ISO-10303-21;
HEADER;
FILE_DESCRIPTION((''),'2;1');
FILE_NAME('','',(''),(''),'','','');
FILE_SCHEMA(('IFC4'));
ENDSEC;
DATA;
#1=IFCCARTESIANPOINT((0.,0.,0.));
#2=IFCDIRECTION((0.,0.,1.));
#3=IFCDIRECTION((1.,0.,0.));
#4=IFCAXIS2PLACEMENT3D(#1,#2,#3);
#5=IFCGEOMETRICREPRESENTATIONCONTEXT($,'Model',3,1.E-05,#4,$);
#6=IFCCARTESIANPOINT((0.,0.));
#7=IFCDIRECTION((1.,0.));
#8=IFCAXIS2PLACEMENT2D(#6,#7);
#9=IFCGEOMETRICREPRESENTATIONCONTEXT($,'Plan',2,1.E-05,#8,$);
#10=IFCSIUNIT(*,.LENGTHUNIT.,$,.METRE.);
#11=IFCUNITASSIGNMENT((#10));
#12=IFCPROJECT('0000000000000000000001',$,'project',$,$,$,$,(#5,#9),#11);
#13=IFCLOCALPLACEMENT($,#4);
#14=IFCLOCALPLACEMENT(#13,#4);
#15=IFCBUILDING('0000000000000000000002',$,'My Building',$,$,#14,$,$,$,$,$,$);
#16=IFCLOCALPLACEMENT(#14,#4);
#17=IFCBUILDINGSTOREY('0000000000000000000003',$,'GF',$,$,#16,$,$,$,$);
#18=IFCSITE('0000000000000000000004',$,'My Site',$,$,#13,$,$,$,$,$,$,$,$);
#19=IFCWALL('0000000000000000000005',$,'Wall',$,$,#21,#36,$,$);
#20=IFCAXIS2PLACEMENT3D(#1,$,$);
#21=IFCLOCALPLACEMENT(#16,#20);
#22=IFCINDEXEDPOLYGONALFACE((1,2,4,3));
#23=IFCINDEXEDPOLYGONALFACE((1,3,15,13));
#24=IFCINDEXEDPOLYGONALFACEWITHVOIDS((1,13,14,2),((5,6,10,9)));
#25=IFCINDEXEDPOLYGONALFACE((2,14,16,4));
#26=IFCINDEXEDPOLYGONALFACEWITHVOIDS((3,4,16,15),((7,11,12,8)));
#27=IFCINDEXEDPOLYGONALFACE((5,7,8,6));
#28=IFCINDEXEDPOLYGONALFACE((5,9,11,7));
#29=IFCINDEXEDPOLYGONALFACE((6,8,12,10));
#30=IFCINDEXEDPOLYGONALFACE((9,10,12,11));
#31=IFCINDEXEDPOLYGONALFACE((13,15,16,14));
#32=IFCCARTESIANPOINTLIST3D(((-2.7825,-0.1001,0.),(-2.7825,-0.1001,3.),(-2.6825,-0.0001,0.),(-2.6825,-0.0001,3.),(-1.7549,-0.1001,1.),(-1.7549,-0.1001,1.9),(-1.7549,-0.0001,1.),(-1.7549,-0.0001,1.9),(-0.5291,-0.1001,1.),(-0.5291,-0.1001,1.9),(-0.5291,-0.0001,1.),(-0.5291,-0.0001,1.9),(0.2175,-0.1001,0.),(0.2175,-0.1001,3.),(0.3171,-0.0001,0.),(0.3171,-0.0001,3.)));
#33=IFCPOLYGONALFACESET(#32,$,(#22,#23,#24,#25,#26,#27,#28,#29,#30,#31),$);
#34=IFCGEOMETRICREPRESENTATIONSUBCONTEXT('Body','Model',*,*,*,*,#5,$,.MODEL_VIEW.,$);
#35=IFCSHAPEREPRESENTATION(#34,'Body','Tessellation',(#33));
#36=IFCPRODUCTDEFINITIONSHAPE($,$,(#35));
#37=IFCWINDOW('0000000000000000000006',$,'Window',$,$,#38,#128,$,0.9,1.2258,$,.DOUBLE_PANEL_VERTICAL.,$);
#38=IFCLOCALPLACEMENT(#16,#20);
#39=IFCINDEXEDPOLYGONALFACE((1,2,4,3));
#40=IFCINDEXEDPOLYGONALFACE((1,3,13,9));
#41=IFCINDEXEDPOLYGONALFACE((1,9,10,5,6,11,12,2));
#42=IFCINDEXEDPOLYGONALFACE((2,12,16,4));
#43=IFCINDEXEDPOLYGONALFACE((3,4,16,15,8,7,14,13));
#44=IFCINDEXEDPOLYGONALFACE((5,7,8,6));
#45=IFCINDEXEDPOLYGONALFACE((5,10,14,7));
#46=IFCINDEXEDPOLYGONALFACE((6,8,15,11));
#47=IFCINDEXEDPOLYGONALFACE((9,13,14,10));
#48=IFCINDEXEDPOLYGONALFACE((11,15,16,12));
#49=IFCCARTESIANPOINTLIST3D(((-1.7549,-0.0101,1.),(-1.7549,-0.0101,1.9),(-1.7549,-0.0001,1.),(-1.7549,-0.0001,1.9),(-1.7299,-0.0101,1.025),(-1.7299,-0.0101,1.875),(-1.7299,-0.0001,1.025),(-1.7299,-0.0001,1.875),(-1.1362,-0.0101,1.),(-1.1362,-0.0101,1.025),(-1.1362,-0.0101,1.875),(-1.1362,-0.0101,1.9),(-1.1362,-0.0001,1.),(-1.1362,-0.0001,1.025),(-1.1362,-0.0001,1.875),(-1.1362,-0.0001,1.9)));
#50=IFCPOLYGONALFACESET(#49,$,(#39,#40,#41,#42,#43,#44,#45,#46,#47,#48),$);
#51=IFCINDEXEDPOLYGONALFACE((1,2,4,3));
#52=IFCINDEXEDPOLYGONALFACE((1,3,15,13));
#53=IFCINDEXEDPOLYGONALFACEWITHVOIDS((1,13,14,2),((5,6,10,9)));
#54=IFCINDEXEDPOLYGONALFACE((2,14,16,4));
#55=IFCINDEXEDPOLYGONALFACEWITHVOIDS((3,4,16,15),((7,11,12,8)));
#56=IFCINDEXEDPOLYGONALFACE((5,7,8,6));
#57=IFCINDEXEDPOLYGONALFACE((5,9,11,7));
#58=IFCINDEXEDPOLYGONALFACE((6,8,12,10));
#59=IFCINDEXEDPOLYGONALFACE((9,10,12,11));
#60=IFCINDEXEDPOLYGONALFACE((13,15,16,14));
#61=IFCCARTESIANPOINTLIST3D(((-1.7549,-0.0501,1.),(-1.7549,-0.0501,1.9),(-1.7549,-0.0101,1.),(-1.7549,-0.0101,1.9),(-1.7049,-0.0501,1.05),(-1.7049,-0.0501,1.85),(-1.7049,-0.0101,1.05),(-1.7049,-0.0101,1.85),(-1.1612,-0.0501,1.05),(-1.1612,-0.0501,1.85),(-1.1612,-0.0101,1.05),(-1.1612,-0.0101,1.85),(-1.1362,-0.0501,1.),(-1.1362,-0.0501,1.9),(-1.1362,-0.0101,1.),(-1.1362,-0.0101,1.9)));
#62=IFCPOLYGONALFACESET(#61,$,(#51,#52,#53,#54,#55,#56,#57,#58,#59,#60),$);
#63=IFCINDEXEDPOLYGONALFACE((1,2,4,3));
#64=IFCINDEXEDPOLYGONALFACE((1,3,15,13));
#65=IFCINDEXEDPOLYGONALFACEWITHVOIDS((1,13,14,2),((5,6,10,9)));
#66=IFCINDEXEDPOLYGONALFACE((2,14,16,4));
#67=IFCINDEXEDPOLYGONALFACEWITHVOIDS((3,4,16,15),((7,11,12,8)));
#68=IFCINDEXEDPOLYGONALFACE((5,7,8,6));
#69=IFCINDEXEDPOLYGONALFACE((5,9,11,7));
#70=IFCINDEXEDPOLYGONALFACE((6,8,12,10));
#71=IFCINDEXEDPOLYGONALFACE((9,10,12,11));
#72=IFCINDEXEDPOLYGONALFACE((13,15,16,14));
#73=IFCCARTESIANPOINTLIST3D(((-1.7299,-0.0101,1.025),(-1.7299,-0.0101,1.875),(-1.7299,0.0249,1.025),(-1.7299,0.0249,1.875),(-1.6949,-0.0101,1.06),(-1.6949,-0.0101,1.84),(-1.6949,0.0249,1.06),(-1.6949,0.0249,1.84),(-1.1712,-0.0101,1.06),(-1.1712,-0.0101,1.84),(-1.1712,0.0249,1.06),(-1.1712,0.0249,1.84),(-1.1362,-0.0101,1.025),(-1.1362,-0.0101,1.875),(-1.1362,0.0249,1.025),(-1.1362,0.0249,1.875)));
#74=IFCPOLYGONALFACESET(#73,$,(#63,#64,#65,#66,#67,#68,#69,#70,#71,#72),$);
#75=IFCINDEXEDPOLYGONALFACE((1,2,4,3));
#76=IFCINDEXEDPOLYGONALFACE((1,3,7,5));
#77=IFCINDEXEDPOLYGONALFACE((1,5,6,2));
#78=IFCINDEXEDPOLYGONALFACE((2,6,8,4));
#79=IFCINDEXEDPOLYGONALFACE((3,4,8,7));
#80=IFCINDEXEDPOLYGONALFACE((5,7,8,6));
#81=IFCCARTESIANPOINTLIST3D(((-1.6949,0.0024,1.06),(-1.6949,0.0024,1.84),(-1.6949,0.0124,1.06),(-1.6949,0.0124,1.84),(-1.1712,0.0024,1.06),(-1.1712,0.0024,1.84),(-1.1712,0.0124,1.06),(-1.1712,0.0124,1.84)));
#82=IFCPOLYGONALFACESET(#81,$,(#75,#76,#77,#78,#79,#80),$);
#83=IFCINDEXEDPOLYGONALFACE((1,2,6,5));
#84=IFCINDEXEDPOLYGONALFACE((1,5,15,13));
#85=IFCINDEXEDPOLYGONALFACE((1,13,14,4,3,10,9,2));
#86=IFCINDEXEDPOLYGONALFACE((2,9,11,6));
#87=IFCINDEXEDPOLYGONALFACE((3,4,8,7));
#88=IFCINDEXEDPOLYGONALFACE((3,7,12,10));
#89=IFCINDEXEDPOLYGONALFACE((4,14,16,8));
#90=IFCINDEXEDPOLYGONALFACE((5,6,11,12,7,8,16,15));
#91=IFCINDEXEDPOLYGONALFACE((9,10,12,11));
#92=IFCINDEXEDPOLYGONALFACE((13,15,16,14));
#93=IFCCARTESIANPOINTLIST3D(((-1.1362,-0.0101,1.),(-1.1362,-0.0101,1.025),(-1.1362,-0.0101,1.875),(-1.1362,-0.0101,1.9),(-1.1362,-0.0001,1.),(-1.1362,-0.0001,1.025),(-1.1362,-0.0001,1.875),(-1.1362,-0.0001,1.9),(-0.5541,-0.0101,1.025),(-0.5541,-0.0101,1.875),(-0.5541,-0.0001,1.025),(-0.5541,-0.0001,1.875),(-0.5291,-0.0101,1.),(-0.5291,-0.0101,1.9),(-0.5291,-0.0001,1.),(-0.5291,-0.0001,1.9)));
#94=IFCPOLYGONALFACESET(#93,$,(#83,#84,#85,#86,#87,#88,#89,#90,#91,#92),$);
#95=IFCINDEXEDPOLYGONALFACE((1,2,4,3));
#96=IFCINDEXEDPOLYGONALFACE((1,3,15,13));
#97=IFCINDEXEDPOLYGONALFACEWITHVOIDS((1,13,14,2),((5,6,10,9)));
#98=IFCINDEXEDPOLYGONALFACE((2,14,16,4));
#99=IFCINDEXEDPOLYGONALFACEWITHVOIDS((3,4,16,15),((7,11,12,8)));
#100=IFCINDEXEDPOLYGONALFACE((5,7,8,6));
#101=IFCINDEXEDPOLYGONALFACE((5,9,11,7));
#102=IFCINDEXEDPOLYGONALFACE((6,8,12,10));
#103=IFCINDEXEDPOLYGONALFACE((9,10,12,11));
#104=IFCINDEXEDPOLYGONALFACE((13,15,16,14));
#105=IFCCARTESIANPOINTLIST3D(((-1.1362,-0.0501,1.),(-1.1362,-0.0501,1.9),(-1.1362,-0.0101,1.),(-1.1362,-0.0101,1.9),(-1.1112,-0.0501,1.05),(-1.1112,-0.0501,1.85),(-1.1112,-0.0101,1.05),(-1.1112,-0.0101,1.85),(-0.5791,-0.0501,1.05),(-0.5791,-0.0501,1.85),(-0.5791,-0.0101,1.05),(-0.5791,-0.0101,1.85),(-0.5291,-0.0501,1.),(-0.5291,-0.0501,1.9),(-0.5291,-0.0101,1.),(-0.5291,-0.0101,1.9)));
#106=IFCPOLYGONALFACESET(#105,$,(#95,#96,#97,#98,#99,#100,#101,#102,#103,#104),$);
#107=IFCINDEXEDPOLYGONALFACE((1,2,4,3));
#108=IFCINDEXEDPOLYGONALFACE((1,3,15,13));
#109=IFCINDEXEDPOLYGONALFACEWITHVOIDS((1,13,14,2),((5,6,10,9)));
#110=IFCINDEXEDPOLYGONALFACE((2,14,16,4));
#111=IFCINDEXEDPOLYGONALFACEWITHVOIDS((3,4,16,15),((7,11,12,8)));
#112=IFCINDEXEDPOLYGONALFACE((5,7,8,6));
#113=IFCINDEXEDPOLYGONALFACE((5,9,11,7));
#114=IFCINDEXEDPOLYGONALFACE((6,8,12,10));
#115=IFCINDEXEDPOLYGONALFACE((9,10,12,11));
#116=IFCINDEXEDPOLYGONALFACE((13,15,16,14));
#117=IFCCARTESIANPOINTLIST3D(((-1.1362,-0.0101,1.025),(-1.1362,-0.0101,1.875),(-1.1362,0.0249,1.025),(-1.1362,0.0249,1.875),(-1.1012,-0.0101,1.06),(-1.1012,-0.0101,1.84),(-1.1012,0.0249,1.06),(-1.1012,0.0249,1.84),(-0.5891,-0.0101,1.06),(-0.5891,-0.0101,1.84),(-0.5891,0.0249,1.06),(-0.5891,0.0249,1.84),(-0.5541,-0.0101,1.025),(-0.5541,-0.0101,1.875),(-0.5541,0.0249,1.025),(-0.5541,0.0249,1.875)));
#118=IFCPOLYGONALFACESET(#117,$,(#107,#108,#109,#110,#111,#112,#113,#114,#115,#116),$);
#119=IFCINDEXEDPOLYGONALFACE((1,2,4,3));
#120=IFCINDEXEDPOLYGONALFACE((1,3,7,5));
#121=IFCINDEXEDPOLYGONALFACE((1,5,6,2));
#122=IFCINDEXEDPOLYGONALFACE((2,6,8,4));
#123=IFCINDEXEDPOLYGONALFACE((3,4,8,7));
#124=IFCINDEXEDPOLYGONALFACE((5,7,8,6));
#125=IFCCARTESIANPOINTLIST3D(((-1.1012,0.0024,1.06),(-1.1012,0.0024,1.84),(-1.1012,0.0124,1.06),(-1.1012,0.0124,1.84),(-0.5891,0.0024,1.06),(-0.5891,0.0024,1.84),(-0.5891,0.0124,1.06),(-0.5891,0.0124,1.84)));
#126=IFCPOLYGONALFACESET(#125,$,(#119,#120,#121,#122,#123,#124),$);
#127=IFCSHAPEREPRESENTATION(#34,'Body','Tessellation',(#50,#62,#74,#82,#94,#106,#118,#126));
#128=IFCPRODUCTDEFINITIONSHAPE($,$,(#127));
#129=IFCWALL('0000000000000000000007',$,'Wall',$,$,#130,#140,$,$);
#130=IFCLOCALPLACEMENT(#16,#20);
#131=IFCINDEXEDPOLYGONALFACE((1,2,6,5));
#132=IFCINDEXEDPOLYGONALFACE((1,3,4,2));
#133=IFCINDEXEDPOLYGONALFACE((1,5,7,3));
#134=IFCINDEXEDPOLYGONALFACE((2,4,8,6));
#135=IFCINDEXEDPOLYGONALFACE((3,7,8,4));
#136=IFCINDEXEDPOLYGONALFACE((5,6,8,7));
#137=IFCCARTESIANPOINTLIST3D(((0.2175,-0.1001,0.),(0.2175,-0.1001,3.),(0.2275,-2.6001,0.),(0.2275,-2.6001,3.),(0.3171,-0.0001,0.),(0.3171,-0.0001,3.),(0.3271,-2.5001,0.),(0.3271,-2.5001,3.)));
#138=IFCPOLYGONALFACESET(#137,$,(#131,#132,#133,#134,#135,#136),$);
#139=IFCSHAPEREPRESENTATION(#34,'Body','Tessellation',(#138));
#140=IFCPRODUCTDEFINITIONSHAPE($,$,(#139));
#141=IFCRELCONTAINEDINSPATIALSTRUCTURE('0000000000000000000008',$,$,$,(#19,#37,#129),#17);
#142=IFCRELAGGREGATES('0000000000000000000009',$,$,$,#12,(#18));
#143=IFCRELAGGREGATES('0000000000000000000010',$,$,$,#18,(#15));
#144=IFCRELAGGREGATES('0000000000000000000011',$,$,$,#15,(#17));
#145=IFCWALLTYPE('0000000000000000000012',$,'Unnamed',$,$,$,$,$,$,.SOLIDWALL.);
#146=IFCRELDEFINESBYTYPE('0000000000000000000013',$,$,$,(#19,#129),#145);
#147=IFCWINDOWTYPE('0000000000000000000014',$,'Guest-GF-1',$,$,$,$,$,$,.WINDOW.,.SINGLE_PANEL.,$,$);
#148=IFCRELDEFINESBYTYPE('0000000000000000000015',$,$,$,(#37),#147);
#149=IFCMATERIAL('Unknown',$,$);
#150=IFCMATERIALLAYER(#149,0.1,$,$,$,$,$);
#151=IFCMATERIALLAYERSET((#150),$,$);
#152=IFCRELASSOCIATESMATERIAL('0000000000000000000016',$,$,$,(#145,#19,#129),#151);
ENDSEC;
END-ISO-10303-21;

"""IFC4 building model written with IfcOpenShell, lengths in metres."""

from ifc_helpers import new_model, entity, si_unit, frame, origin_with_axes, origin_2d_with_axis, place, context, subcontext, project, spatial, line, indexed_curve, outline, extrude, shape, source, transform, mapped, material, layer, layer_set, layer_usage, type_object, type_shapes, element, fill, save


model = new_model("IFC4")

# Units and contexts
model_context = context("Model", 3, precision=1e-05, world=origin_with_axes())
plan_context = context("Plan", 2, precision=1e-05, world=origin_2d_with_axis())
body_context_1 = subcontext(model_context, "Body", "Model", "MODEL_VIEW")
body_context_2 = subcontext(plan_context, "Body", "Plan", "PLAN_VIEW")
ifc_project = project(units=[si_unit("LENGTHUNIT", "METRE")], contexts=[model_context, plan_context])

# Site, building, storey
site_placement = place(None, origin_with_axes())
site = spatial("IfcSite", under=ifc_project, at=site_placement, Name="My Site")
building_placement = place(site_placement, origin_with_axes())
building = spatial("IfcBuilding", under=site, at=building_placement, Name="My Building")
storey_placement = place(building_placement, origin_with_axes())
storey = spatial("IfcBuildingStorey", under=building, at=storey_placement, Name="GF")

# Shared definitions
ifc_material = material(Name="Unknown")

# Shared definitions
ifc_layer_1 = layer(ifc_material, 0.1)
ifc_layer_set_1 = layer_set([ifc_layer_1])
wall_type = type_object("IfcWallType", Name="Unnamed", PredefinedType="SOLIDWALL", material=ifc_layer_set_1)

# Wall, opening, window
ifc_layer_usage_1 = layer_usage(ifc_layer_set_1, "AXIS2", "POSITIVE", 0.0)
wall_1_placement = place(storey_placement, frame((-2.7825, -0.1001, 0.0), z_axis=(0.0, 0.0, 1.0), x_axis=(1.0, 0.0, 0.0)))
wall_1 = element("IfcWall", 1, at=wall_1_placement, inside=storey, type_object=wall_type, material=ifc_layer_usage_1, Name="Wall", context=body_context_1, shape_type="SweptSolid", body=[
    extrude(outline(indexed_curve([(0.0, 0.0), (0.1, 0.1), (3.0996, 0.1), (3.0, 0.0)], segments=[line(1, 2, 3, 4, 1)])), origin_with_axes(), (0.0, 0.0, 1.0), 3.0),
])
shared_shape_1 = source(origin_with_axes(), body_context_1, "Body", "SweptSolid", [
    extrude(outline(indexed_curve([(0.0, 0.0), (1.2258, 0.0), (1.2258, 0.9), (0.0, 0.9)], segments=[line(1, 2, 3, 4, 1)])), frame((0.0, -0.6, 0.0), z_axis=(0.0, -1.0, 0.0), x_axis=(1.0, 0.0, 0.0)), (0.0, 0.0, -1.0), 1.2),
])
opening_1_placement = place(wall_1_placement, frame((1.0276, 0.0, 1.0), z_axis=(0.0, 0.0, 1.0), x_axis=(1.0, 0.0, 0.0)))
opening_1 = element("IfcOpeningElement", 2, at=opening_1_placement, cuts=wall_1, PredefinedType="OPENING", context=body_context_1, shape_type="MappedRepresentation", body=[
    mapped(shared_shape_1, transform((0.0, 0.0, 0.0), x_axis=(1.0, 0.0, 0.0), y_axis=(0.0, 1.0, 0.0), z_axis=(0.0, 0.0, 1.0), scale=1.0)),
])
window_type_1 = type_object("IfcWindowType", Name="Guest-GF-1", PartitioningType="SINGLE_PANEL", PredefinedType="WINDOW")
shared_shape_2 = source(origin_with_axes(), body_context_1, "Body", "SweptSolid", [
    extrude(outline(indexed_curve([(0.6187, 0.0), (0.0, 0.0), (0.0, 0.9), (0.6187, 0.9), (0.6187, 0.875), (0.025, 0.875), (0.025, 0.025), (0.6187, 0.025)], segments=[line(1, 2, 3, 4, 5, 6, 7, 8, 1)])), frame((0.0, 0.09, 0.0), z_axis=(0.0, -1.0, 0.0), x_axis=(1.0, 0.0, 0.0)), (0.0, 0.0, -1.0), 0.01),
    extrude(outline(indexed_curve([(0.0, 0.0), (0.6187, 0.0), (0.6187, 0.9), (0.0, 0.9)], segments=[line(1, 2, 3, 4, 1)]), holes=[indexed_curve([(0.05, 0.05), (0.5937, 0.05), (0.5937, 0.85), (0.05, 0.85)], segments=[line(1, 2, 3, 4, 1)])]), frame((0.0, 0.05, 0.0), z_axis=(0.0, -1.0, 0.0), x_axis=(1.0, 0.0, 0.0)), (0.0, 0.0, -1.0), 0.04),
    extrude(outline(indexed_curve([(0.0, 0.0), (0.5937, 0.0), (0.5937, 0.85), (0.0, 0.85)], segments=[line(1, 2, 3, 4, 1)]), holes=[indexed_curve([(0.035, 0.035), (0.5587, 0.035), (0.5587, 0.815), (0.035, 0.815)], segments=[line(1, 2, 3, 4, 1)])]), frame((0.025, 0.09, 0.025), z_axis=(0.0, -1.0, 0.0), x_axis=(1.0, 0.0, 0.0)), (0.0, 0.0, -1.0), 0.035),
    extrude(outline(indexed_curve([(0.035, 0.035), (0.5587, 0.035), (0.5587, 0.815), (0.035, 0.815)], segments=[line(1, 2, 3, 4, 1)])), frame((0.025, 0.1025, 0.025), z_axis=(0.0, -1.0, 0.0), x_axis=(1.0, 0.0, 0.0)), (0.0, 0.0, -1.0), 0.01),
    extrude(outline(indexed_curve([(0.0, 0.9), (0.6071, 0.9), (0.6071, 0.0), (0.0, 0.0), (0.0, 0.025), (0.5821, 0.025), (0.5821, 0.875), (0.0, 0.875)], segments=[line(1, 2, 3, 4, 5, 6, 7, 8, 1)])), frame((0.6187, 0.09, 0.0), z_axis=(0.0, -1.0, 0.0), x_axis=(1.0, 0.0, 0.0)), (0.0, 0.0, -1.0), 0.01),
    extrude(outline(indexed_curve([(0.0, 0.0), (0.6071, 0.0), (0.6071, 0.9), (0.0, 0.9)], segments=[line(1, 2, 3, 4, 1)]), holes=[indexed_curve([(0.025, 0.05), (0.5571, 0.05), (0.5571, 0.85), (0.025, 0.85)], segments=[line(1, 2, 3, 4, 1)])]), frame((0.6187, 0.05, 0.0), z_axis=(0.0, -1.0, 0.0), x_axis=(1.0, 0.0, 0.0)), (0.0, 0.0, -1.0), 0.04),
    extrude(outline(indexed_curve([(0.0, 0.0), (0.5821, 0.0), (0.5821, 0.85), (0.0, 0.85)], segments=[line(1, 2, 3, 4, 1)]), holes=[indexed_curve([(0.035, 0.035), (0.5471, 0.035), (0.5471, 0.815), (0.035, 0.815)], segments=[line(1, 2, 3, 4, 1)])]), frame((0.6187, 0.09, 0.025), z_axis=(0.0, -1.0, 0.0), x_axis=(1.0, 0.0, 0.0)), (0.0, 0.0, -1.0), 0.035),
    extrude(outline(indexed_curve([(0.035, 0.035), (0.5471, 0.035), (0.5471, 0.815), (0.035, 0.815)], segments=[line(1, 2, 3, 4, 1)])), frame((0.6187, 0.1025, 0.025), z_axis=(0.0, -1.0, 0.0), x_axis=(1.0, 0.0, 0.0)), (0.0, 0.0, -1.0), 0.01),
])
shared_shape_3 = source(origin_with_axes(), body_context_2, "Body", "Curve2D", [
    entity("IfcIndexedPolyCurve", entity("IfcCartesianPointList2D", [[0.05, 0.05], [0.5937, 0.05]])),
    entity("IfcIndexedPolyCurve", entity("IfcCartesianPointList2D", [[0.0, 0.1], [0.025, 0.1], [0.025, 0.09], [0.05, 0.09], [0.05, 0.05], [0.0, 0.05]]), [entity("IfcLineIndex", [1, 2, 3, 4, 5, 6, 1])]),
    entity("IfcIndexedPolyCurve", entity("IfcCartesianPointList2D", [[0.6187, 0.1], [0.6187, 0.1], [0.6187, 0.09], [0.5937, 0.09], [0.5937, 0.05], [0.6187, 0.05]])),
    entity("IfcIndexedPolyCurve", entity("IfcCartesianPointList2D", [[0.025, 0.09], [0.06, 0.09], [0.06, 0.125], [0.025, 0.125]]), [entity("IfcLineIndex", [1, 2, 3, 4, 1])]),
    entity("IfcIndexedPolyCurve", entity("IfcCartesianPointList2D", [[0.6187, 0.09], [0.5837, 0.09], [0.5837, 0.125], [0.6187, 0.125]]), [entity("IfcLineIndex", [1, 2, 3, 4, 1])]),
    entity("IfcIndexedPolyCurve", entity("IfcCartesianPointList2D", [[0.06, 0.09], [0.5837, 0.09]])),
    entity("IfcIndexedPolyCurve", entity("IfcCartesianPointList2D", [[0.06, 0.125], [0.5837, 0.125]])),
    entity("IfcIndexedPolyCurve", entity("IfcCartesianPointList2D", [[0.06, 0.1075], [0.5837, 0.1075]])),
    entity("IfcIndexedPolyCurve", entity("IfcCartesianPointList2D", [[0.6437, 0.05], [1.1758, 0.05]])),
    entity("IfcIndexedPolyCurve", entity("IfcCartesianPointList2D", [[0.6187, 0.1], [0.6187, 0.1], [0.6187, 0.09], [0.6437, 0.09], [0.6437, 0.05], [0.6187, 0.05]])),
    entity("IfcIndexedPolyCurve", entity("IfcCartesianPointList2D", [[1.2258, 0.1], [1.2008, 0.1], [1.2008, 0.09], [1.1758, 0.09], [1.1758, 0.05], [1.2258, 0.05]]), [entity("IfcLineIndex", [1, 2, 3, 4, 5, 6, 1])]),
    entity("IfcIndexedPolyCurve", entity("IfcCartesianPointList2D", [[0.6187, 0.09], [0.6537, 0.09], [0.6537, 0.125], [0.6187, 0.125]]), [entity("IfcLineIndex", [1, 2, 3, 4, 1])]),
    entity("IfcIndexedPolyCurve", entity("IfcCartesianPointList2D", [[1.2008, 0.09], [1.1658, 0.09], [1.1658, 0.125], [1.2008, 0.125]]), [entity("IfcLineIndex", [1, 2, 3, 4, 1])]),
    entity("IfcIndexedPolyCurve", entity("IfcCartesianPointList2D", [[0.6537, 0.09], [1.1658, 0.09]])),
    entity("IfcIndexedPolyCurve", entity("IfcCartesianPointList2D", [[0.6537, 0.125], [1.1658, 0.125]])),
    entity("IfcIndexedPolyCurve", entity("IfcCartesianPointList2D", [[0.6537, 0.1075], [1.1658, 0.1075]])),
])
type_shapes(window_type_1, [shared_shape_2, shared_shape_3])
window_1_placement = place(opening_1_placement, frame((0.0, 0.0, 0.0), z_axis=(0.0, 0.0, 1.0), x_axis=(1.0, 0.0, 0.0)))
window_1 = element("IfcWindow", 3, at=window_1_placement, inside=storey, type_object=window_type_1, Name="Window", OverallHeight=0.9, OverallWidth=1.2258, PartitioningType="DOUBLE_PANEL_VERTICAL", shapes=[
    shape(body_context_1, "Body", "MappedRepresentation", [mapped(shared_shape_2, transform((0.0, 0.0, 0.0), x_axis=(1.0, 0.0, 0.0), y_axis=(0.0, 1.0, 0.0), z_axis=(0.0, 0.0, 1.0), scale=1.0))]),
    shape(body_context_2, "Body", "MappedRepresentation", [mapped(shared_shape_3, transform((0.0, 0.0, 0.0), x_axis=(1.0, 0.0, 0.0), y_axis=(0.0, 1.0, 0.0), z_axis=(0.0, 0.0, 1.0), scale=1.0))]),
])
fill(opening_1, window_1)

# Wall
ifc_layer_usage_2 = layer_usage(ifc_layer_set_1, "AXIS2", "POSITIVE", 0.0)
wall_2_placement = place(storey_placement, frame((0.2175, -0.1001, 0.0), z_axis=(0.0, 0.0, 1.0), x_axis=(0.003999, -0.999992, 0.0)))
element("IfcWall", 4, at=wall_2_placement, inside=storey, type_object=wall_type, material=ifc_layer_usage_2, Name="Wall", context=body_context_1, shape_type="SweptSolid", body=[
    extrude(outline(indexed_curve([(0.0, 0.0), (-0.0996, 0.1), (2.4004, 0.1), (2.5, 0.0)], segments=[line(1, 2, 3, 4, 1)])), origin_with_axes(), (0.0, 0.0, 1.0), 3.0),
])

save(model, "model.ifc")
